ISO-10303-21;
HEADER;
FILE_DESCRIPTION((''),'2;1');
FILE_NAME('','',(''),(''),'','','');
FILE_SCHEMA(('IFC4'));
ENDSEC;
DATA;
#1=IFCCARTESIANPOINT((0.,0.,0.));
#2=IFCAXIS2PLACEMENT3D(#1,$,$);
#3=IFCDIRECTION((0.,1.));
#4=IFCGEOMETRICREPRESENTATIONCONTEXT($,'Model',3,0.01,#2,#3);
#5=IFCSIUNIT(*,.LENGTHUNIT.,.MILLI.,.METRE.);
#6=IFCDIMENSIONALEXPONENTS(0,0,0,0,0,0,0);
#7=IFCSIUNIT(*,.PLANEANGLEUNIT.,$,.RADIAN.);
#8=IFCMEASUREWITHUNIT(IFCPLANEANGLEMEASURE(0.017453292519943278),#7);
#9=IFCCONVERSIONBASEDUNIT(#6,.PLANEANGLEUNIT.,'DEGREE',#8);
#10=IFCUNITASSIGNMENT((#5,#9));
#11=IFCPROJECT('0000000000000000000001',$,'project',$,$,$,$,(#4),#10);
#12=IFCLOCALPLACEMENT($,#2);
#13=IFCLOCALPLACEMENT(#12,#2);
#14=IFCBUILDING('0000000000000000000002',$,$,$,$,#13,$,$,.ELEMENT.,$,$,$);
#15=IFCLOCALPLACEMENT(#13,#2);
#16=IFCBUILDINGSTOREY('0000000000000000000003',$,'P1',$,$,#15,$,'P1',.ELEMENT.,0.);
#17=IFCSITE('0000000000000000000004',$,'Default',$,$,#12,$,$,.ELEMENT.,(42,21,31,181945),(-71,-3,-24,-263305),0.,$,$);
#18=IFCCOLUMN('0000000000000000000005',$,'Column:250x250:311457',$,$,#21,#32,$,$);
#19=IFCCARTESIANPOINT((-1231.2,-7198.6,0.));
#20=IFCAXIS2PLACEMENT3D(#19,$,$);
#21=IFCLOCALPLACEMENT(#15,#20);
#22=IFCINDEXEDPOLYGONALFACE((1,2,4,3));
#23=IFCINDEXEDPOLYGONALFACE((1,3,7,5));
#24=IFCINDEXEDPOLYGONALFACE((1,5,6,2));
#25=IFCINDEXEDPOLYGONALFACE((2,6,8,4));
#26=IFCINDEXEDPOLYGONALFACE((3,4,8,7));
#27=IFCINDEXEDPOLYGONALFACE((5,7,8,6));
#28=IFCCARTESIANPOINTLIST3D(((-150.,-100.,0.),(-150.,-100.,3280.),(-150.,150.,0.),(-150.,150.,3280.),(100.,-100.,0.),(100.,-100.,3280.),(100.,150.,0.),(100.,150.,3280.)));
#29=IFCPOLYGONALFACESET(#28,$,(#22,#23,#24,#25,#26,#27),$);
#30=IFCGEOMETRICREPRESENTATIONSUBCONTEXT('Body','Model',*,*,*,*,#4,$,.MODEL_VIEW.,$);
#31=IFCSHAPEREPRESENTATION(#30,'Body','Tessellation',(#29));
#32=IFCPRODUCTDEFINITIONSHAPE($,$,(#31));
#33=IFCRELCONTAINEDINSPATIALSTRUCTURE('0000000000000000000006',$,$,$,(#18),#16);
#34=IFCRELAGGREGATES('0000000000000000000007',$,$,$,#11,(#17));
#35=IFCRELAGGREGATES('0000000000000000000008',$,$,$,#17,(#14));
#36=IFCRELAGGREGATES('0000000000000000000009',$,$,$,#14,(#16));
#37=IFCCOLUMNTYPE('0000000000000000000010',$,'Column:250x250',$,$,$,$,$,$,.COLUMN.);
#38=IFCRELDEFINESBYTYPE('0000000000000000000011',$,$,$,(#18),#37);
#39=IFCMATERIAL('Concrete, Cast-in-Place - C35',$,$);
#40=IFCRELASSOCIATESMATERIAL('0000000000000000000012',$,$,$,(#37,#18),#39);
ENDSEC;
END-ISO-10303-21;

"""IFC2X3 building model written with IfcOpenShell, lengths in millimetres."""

from ifc_helpers import new_model, entity, si_unit, converted_unit, direction, frame, origin, origin_2d_with_axis, place, context, subcontext, project, spatial, rectangle, extrude, source, transform, mapped, material, type_object, type_shapes, element, save


model = new_model("IFC2X3")

# Units and contexts
model_context = context("Model", 3, precision=0.01, world=origin(), true_north=direction((0.0, 1.0)))
body_context = subcontext(model_context, "Body", "Model", "MODEL_VIEW")
ifc_project = project(units=[si_unit("LENGTHUNIT", "METRE", prefix="MILLI"), converted_unit("PLANEANGLEUNIT", "DEGREE", entity("IfcPlaneAngleMeasure", 0.017453292519943278), si_unit("PLANEANGLEUNIT", "RADIAN"), dimensions=[0, 0, 0, 0, 0, 0, 0])], contexts=[model_context])

# Site, building, storey
site_placement = place(None, origin())
site = spatial("IfcSite", under=ifc_project, at=site_placement, Name="Default", CompositionType="ELEMENT", RefLatitude=(42, 21, 31, 181945), RefLongitude=(-71, -3, -24, -263305), RefElevation=0.0)
building_placement = place(site_placement, origin())
building = spatial("IfcBuilding", under=site, at=building_placement, CompositionType="ELEMENT")
storey_placement = place(building_placement, origin())
storey = spatial("IfcBuildingStorey", under=building, at=storey_placement, Name="P1", LongName="P1", CompositionType="ELEMENT", Elevation=0.0)

# Column
ifc_material_1 = material(Name="Concrete, Cast-in-Place - C35")
column_type = type_object("IfcColumnType", Name="Column:250x250", PredefinedType="COLUMN", material=ifc_material_1)
shared_shape = source(origin(), body_context, "Body", "SweptSolid", [
    extrude(rectangle(XDim=250.0, YDim=250.0, at=origin_2d_with_axis()), frame((-25.0, 25.0, 0.0), z_axis=(0.0, 0.0, 1.0), x_axis=(-1.0, 0.0, 0.0)), (0.0, 0.0, 1.0), 3280.0),
])
type_shapes(column_type, [shared_shape])
column_placement = place(storey_placement, frame((-1231.2, -7198.6, 0.0)))
element("IfcColumn", 1, at=column_placement, inside=storey, type_object=column_type, material=ifc_material_1, Name="Column:250x250:311457", context=body_context, shape_type="MappedRepresentation", body=[
    mapped(shared_shape, transform((0.0, 0.0, 0.0), scale=1.0)),
])

save(model, "model.ifc")
